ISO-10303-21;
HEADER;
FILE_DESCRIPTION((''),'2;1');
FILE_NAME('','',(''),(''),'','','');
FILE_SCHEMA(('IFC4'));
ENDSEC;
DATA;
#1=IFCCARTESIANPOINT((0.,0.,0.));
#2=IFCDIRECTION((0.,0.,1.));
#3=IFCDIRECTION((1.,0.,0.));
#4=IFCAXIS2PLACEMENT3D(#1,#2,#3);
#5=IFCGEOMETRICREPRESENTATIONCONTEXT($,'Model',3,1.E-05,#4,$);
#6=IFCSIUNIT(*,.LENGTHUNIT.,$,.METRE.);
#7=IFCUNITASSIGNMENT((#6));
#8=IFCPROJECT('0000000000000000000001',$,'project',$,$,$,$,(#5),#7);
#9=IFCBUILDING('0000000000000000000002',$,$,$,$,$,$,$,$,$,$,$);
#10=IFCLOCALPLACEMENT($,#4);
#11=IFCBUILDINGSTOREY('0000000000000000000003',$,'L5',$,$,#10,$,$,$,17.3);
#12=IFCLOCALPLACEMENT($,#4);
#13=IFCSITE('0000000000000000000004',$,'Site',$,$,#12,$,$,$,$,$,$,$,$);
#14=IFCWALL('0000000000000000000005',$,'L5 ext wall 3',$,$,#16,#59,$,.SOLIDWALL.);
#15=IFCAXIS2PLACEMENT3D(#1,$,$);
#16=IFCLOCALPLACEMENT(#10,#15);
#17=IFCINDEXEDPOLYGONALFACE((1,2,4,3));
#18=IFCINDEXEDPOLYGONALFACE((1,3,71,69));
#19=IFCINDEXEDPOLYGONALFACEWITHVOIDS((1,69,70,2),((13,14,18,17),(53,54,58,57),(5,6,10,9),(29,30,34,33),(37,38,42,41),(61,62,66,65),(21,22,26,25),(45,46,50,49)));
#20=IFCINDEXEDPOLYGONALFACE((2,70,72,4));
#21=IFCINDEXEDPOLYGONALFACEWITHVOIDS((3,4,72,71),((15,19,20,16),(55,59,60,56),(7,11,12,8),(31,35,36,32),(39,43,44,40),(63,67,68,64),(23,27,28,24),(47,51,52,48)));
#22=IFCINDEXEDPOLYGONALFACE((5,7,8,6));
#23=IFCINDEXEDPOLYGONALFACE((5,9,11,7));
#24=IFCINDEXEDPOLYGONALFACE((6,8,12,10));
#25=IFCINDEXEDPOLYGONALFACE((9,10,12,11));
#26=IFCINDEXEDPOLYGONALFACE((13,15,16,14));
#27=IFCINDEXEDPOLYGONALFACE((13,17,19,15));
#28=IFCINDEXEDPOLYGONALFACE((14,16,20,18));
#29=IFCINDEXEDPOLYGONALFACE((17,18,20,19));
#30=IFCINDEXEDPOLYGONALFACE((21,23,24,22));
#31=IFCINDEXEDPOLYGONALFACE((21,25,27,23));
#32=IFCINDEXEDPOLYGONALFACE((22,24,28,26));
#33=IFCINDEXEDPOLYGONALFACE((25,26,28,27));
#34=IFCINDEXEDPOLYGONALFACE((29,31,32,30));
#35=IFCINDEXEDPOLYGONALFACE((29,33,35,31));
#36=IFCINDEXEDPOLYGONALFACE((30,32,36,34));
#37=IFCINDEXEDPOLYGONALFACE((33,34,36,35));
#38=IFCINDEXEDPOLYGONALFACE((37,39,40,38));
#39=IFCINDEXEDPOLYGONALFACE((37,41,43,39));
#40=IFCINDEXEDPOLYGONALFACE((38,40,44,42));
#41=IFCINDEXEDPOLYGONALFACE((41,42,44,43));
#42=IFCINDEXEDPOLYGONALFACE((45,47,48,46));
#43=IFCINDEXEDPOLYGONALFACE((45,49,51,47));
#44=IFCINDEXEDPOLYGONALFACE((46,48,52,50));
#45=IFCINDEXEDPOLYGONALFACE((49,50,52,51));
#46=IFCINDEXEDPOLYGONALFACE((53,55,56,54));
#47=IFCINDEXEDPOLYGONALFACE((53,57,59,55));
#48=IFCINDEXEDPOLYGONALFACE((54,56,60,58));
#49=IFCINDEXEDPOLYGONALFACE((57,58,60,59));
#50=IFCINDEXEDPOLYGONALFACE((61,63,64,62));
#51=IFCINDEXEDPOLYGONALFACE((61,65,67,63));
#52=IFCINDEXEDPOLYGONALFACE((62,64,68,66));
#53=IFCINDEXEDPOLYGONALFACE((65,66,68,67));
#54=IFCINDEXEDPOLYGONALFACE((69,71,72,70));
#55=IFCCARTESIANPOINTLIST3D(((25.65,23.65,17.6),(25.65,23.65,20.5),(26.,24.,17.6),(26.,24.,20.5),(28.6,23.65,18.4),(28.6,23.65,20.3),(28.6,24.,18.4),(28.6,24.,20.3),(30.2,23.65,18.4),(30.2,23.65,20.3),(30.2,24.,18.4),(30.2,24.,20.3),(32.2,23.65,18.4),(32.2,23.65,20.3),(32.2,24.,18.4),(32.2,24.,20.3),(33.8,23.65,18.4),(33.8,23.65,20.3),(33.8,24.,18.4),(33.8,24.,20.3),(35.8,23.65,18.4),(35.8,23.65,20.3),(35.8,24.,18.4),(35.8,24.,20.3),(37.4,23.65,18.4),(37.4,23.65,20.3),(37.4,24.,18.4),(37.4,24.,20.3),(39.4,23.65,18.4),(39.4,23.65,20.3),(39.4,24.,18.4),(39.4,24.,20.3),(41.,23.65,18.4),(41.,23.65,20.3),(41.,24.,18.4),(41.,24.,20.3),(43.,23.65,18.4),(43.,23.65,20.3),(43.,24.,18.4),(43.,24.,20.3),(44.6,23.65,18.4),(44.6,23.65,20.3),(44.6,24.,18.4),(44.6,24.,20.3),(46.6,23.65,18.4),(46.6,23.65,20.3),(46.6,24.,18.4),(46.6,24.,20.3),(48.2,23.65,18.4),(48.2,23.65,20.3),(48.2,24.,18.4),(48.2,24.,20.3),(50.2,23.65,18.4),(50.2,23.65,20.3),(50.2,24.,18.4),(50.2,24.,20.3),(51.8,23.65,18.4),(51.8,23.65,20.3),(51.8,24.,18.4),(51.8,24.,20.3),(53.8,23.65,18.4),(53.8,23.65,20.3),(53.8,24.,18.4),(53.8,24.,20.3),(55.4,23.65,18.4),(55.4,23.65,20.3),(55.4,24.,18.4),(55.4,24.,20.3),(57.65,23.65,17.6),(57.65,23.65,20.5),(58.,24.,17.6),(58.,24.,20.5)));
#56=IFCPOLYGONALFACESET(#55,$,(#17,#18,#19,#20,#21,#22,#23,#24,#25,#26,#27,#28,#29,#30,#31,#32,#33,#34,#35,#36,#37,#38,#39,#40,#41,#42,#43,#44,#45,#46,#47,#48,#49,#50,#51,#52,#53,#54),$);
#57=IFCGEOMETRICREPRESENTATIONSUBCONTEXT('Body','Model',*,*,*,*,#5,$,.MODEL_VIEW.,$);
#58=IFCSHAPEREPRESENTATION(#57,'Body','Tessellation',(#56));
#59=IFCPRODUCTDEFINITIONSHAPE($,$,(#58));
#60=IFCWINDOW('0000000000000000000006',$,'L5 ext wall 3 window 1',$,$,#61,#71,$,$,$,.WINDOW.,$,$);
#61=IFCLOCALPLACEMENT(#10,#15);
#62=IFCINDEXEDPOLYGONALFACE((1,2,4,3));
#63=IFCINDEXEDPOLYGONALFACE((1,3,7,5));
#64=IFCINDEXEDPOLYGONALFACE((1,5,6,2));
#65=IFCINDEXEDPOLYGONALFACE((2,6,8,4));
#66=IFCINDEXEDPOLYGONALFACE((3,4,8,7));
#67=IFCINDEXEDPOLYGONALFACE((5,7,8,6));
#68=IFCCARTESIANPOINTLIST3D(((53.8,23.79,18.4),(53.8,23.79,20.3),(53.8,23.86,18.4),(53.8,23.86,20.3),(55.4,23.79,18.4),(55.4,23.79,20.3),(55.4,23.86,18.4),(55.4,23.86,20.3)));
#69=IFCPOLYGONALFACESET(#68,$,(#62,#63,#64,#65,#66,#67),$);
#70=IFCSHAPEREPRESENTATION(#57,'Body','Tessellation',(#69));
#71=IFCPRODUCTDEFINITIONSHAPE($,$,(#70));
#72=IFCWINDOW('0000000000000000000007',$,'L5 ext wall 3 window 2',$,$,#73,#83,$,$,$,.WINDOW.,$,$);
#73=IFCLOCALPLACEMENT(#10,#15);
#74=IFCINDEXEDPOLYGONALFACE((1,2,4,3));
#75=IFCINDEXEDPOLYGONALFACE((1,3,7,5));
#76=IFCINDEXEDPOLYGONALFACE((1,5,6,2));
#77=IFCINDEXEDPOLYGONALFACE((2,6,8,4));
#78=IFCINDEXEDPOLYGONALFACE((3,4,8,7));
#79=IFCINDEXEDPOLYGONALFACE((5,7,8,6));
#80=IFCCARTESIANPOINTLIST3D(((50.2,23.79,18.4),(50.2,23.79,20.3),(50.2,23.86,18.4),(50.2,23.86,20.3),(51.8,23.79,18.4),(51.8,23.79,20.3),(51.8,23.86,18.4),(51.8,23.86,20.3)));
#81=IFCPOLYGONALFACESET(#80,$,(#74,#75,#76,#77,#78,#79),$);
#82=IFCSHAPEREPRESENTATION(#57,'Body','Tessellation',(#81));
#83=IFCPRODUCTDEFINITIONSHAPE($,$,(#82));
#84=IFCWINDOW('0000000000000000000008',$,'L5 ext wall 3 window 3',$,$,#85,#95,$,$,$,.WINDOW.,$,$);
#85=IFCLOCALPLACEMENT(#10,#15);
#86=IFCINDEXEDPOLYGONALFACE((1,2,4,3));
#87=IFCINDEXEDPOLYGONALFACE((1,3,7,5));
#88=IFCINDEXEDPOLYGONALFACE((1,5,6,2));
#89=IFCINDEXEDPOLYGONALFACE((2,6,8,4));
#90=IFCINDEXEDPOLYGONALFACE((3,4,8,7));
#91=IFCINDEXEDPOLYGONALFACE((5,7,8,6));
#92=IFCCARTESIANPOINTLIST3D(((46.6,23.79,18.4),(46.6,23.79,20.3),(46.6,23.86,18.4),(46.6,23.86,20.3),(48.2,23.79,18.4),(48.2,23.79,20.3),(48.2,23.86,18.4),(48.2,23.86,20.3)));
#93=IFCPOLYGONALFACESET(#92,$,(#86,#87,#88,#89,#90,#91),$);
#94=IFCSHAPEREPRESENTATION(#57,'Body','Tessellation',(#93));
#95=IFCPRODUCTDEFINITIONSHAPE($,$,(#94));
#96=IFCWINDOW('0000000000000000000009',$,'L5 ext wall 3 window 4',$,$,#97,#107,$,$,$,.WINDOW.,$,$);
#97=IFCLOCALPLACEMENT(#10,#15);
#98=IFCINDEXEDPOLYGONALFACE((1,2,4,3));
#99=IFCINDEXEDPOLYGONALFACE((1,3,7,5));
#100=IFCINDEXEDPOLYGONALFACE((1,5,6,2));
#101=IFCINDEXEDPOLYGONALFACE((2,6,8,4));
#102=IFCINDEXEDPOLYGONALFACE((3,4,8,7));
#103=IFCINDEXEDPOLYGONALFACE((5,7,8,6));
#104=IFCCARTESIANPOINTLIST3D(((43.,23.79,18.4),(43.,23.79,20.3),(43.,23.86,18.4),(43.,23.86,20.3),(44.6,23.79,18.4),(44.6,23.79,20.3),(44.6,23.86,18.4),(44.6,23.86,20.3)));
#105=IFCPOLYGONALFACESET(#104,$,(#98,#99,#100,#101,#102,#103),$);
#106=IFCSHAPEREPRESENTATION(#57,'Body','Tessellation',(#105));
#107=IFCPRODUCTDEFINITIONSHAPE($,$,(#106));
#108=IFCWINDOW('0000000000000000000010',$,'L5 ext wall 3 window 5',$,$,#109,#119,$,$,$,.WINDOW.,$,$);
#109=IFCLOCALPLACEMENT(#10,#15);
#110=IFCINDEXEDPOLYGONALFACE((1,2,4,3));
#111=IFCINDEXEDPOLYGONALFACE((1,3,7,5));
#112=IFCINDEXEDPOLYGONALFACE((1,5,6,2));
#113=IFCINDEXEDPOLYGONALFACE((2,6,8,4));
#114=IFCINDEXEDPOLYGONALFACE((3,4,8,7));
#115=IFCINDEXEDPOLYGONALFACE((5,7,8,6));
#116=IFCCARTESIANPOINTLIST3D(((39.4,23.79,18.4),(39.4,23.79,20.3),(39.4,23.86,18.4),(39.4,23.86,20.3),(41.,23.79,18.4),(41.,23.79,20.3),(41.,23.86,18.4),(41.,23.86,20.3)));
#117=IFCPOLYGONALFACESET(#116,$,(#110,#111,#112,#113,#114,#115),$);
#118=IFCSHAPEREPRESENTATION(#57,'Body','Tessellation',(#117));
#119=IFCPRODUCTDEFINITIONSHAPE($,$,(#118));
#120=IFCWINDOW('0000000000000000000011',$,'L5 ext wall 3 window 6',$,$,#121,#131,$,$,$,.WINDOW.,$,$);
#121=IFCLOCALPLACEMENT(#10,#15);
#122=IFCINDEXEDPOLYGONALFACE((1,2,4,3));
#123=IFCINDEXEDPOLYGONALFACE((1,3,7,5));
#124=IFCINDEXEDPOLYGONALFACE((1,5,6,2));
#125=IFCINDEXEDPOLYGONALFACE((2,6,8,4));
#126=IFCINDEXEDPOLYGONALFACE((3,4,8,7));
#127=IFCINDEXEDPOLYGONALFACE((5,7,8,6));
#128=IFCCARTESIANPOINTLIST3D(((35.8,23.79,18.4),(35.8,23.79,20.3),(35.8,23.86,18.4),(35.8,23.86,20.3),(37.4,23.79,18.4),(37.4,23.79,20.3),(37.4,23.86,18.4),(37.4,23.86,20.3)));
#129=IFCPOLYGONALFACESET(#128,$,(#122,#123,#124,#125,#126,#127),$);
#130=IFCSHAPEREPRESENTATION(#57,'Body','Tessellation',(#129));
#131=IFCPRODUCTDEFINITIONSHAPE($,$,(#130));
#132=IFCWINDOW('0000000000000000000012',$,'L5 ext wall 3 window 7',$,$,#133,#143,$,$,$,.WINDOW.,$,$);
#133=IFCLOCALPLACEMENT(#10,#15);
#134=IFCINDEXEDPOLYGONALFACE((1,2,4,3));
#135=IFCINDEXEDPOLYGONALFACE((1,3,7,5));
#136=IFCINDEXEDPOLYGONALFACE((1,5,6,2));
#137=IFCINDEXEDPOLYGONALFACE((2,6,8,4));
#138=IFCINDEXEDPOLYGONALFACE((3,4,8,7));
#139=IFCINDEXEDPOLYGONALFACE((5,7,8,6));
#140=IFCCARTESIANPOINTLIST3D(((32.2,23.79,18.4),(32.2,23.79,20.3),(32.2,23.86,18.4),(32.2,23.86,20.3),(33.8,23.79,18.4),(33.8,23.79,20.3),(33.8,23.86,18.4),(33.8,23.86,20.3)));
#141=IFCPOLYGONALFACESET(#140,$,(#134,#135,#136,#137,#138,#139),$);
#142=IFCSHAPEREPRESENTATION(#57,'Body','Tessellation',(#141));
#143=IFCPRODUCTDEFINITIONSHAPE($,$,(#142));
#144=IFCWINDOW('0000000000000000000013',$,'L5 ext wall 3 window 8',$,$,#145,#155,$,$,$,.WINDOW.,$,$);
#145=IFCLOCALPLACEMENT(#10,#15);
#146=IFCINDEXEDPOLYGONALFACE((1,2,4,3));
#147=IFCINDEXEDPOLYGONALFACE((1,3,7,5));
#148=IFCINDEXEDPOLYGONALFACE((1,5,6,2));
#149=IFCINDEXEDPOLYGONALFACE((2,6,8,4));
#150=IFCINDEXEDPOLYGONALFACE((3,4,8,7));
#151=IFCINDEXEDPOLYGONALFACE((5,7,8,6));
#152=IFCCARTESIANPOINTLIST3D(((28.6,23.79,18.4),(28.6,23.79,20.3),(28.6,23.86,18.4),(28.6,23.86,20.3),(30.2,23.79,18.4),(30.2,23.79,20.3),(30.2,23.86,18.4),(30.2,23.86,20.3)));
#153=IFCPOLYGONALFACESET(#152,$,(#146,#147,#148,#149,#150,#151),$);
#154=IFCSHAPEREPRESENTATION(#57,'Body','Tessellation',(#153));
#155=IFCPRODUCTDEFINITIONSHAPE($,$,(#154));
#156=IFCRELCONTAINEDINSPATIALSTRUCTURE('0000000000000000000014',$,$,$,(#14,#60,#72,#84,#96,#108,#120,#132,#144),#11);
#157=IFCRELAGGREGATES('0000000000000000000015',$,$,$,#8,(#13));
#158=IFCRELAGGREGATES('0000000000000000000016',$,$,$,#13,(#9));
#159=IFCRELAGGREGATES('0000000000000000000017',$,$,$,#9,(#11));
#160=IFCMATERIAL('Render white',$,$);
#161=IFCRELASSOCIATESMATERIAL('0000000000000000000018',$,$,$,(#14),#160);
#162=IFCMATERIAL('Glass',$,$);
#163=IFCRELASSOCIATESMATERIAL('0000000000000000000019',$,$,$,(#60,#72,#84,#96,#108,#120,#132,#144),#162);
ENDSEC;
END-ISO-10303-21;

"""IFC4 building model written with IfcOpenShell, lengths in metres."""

from ifc_helpers import new_model, si_unit, frame, origin_with_axes, place, context, subcontext, project, spatial, polyline, outline, extrude, material, element, fill, save


model = new_model("IFC4")

# Units and contexts
model_context = context("Model", 3, precision=1e-05, world=origin_with_axes())
body_context = subcontext(model_context, "Body", "Model", "MODEL_VIEW")
ifc_project = project(units=[si_unit("LENGTHUNIT", "METRE")], contexts=[model_context])

# Site, building, storey
site_placement = place(None, origin_with_axes())
site = spatial("IfcSite", under=ifc_project, at=site_placement, Name="Site")
building = spatial("IfcBuilding", under=site)
storey_placement = place(None, origin_with_axes())
storey = spatial("IfcBuildingStorey", under=building, at=storey_placement, Name="L5", Elevation=17.3)

# Wall, openings, windows
ifc_material_1 = material(Name="Render white")
wall_1_placement = place(storey_placement, origin_with_axes())
wall_1 = element("IfcWall", 1, at=wall_1_placement, inside=storey, material=ifc_material_1, Name="L5 ext wall 3", PredefinedType="SOLIDWALL", context=body_context, shape_type="SweptSolid", body=[
    extrude(outline(polyline([(58.0, 24.0), (26.0, 24.0), (25.65, 23.65), (57.65, 23.65), (58.0, 24.0)])), frame((0.0, 0.0, 17.6), z_axis=(0.0, 0.0, 1.0), x_axis=(1.0, 0.0, 0.0)), (0.0, 0.0, 1.0), 2.9),
])
opening_1_placement = place(wall_1_placement, origin_with_axes())
opening_1 = element("IfcOpeningElement", 2, at=opening_1_placement, cuts=wall_1, context=body_context, shape_type="SweptSolid", body=[
    extrude(outline(polyline([(55.4, 24.05), (53.8, 24.05), (53.8, 23.6), (55.4, 23.6), (55.4, 24.05)])), frame((0.0, 0.0, 18.4), z_axis=(0.0, 0.0, 1.0), x_axis=(1.0, 0.0, 0.0)), (0.0, 0.0, 1.0), 1.9),
])
opening_2_placement = place(wall_1_placement, origin_with_axes())
opening_2 = element("IfcOpeningElement", 3, at=opening_2_placement, cuts=wall_1, context=body_context, shape_type="SweptSolid", body=[
    extrude(outline(polyline([(51.8, 24.05), (50.2, 24.05), (50.2, 23.6), (51.8, 23.6), (51.8, 24.05)])), frame((0.0, 0.0, 18.4), z_axis=(0.0, 0.0, 1.0), x_axis=(1.0, 0.0, 0.0)), (0.0, 0.0, 1.0), 1.9),
])
opening_3_placement = place(wall_1_placement, origin_with_axes())
opening_3 = element("IfcOpeningElement", 4, at=opening_3_placement, cuts=wall_1, context=body_context, shape_type="SweptSolid", body=[
    extrude(outline(polyline([(48.2, 24.05), (46.6, 24.05), (46.6, 23.6), (48.2, 23.6), (48.2, 24.05)])), frame((0.0, 0.0, 18.4), z_axis=(0.0, 0.0, 1.0), x_axis=(1.0, 0.0, 0.0)), (0.0, 0.0, 1.0), 1.9),
])
opening_4_placement = place(wall_1_placement, origin_with_axes())
opening_4 = element("IfcOpeningElement", 5, at=opening_4_placement, cuts=wall_1, context=body_context, shape_type="SweptSolid", body=[
    extrude(outline(polyline([(44.6, 24.05), (43.0, 24.05), (43.0, 23.6), (44.6, 23.6), (44.6, 24.05)])), frame((0.0, 0.0, 18.4), z_axis=(0.0, 0.0, 1.0), x_axis=(1.0, 0.0, 0.0)), (0.0, 0.0, 1.0), 1.9),
])
opening_5_placement = place(wall_1_placement, origin_with_axes())
opening_5 = element("IfcOpeningElement", 6, at=opening_5_placement, cuts=wall_1, context=body_context, shape_type="SweptSolid", body=[
    extrude(outline(polyline([(41.0, 24.05), (39.4, 24.05), (39.4, 23.6), (41.0, 23.6), (41.0, 24.05)])), frame((0.0, 0.0, 18.4), z_axis=(0.0, 0.0, 1.0), x_axis=(1.0, 0.0, 0.0)), (0.0, 0.0, 1.0), 1.9),
])
opening_6_placement = place(wall_1_placement, origin_with_axes())
opening_6 = element("IfcOpeningElement", 7, at=opening_6_placement, cuts=wall_1, context=body_context, shape_type="SweptSolid", body=[
    extrude(outline(polyline([(37.4, 24.05), (35.8, 24.05), (35.8, 23.6), (37.4, 23.6), (37.4, 24.05)])), frame((0.0, 0.0, 18.4), z_axis=(0.0, 0.0, 1.0), x_axis=(1.0, 0.0, 0.0)), (0.0, 0.0, 1.0), 1.9),
])
opening_7_placement = place(wall_1_placement, origin_with_axes())
opening_7 = element("IfcOpeningElement", 8, at=opening_7_placement, cuts=wall_1, context=body_context, shape_type="SweptSolid", body=[
    extrude(outline(polyline([(33.8, 24.05), (32.2, 24.05), (32.2, 23.6), (33.8, 23.6), (33.8, 24.05)])), frame((0.0, 0.0, 18.4), z_axis=(0.0, 0.0, 1.0), x_axis=(1.0, 0.0, 0.0)), (0.0, 0.0, 1.0), 1.9),
])
opening_8_placement = place(wall_1_placement, origin_with_axes())
opening_8 = element("IfcOpeningElement", 9, at=opening_8_placement, cuts=wall_1, context=body_context, shape_type="SweptSolid", body=[
    extrude(outline(polyline([(30.2, 24.05), (28.6, 24.05), (28.6, 23.6), (30.2, 23.6), (30.2, 24.05)])), frame((0.0, 0.0, 18.4), z_axis=(0.0, 0.0, 1.0), x_axis=(1.0, 0.0, 0.0)), (0.0, 0.0, 1.0), 1.9),
])
ifc_material_2 = material(Name="Glass")
window_1_placement = place(storey_placement, origin_with_axes())
window_1 = element("IfcWindow", 10, at=window_1_placement, inside=storey, material=ifc_material_2, Name="L5 ext wall 3 window 1", PredefinedType="WINDOW", context=body_context, shape_type="SweptSolid", body=[
    extrude(outline(polyline([(55.4, 23.86), (53.8, 23.86), (53.8, 23.79), (55.4, 23.79), (55.4, 23.86)])), frame((0.0, 0.0, 18.4), z_axis=(0.0, 0.0, 1.0), x_axis=(1.0, 0.0, 0.0)), (0.0, 0.0, 1.0), 1.9),
])
fill(opening_1, window_1)
window_2_placement = place(storey_placement, origin_with_axes())
window_2 = element("IfcWindow", 11, at=window_2_placement, inside=storey, material=ifc_material_2, Name="L5 ext wall 3 window 2", PredefinedType="WINDOW", context=body_context, shape_type="SweptSolid", body=[
    extrude(outline(polyline([(51.8, 23.86), (50.2, 23.86), (50.2, 23.79), (51.8, 23.79), (51.8, 23.86)])), frame((0.0, 0.0, 18.4), z_axis=(0.0, 0.0, 1.0), x_axis=(1.0, 0.0, 0.0)), (0.0, 0.0, 1.0), 1.9),
])
fill(opening_2, window_2)
window_3_placement = place(storey_placement, origin_with_axes())
window_3 = element("IfcWindow", 12, at=window_3_placement, inside=storey, material=ifc_material_2, Name="L5 ext wall 3 window 3", PredefinedType="WINDOW", context=body_context, shape_type="SweptSolid", body=[
    extrude(outline(polyline([(48.2, 23.86), (46.6, 23.86), (46.6, 23.79), (48.2, 23.79), (48.2, 23.86)])), frame((0.0, 0.0, 18.4), z_axis=(0.0, 0.0, 1.0), x_axis=(1.0, 0.0, 0.0)), (0.0, 0.0, 1.0), 1.9),
])
fill(opening_3, window_3)
window_4_placement = place(storey_placement, origin_with_axes())
window_4 = element("IfcWindow", 13, at=window_4_placement, inside=storey, material=ifc_material_2, Name="L5 ext wall 3 window 4", PredefinedType="WINDOW", context=body_context, shape_type="SweptSolid", body=[
    extrude(outline(polyline([(44.6, 23.86), (43.0, 23.86), (43.0, 23.79), (44.6, 23.79), (44.6, 23.86)])), frame((0.0, 0.0, 18.4), z_axis=(0.0, 0.0, 1.0), x_axis=(1.0, 0.0, 0.0)), (0.0, 0.0, 1.0), 1.9),
])
fill(opening_4, window_4)
window_5_placement = place(storey_placement, origin_with_axes())
window_5 = element("IfcWindow", 14, at=window_5_placement, inside=storey, material=ifc_material_2, Name="L5 ext wall 3 window 5", PredefinedType="WINDOW", context=body_context, shape_type="SweptSolid", body=[
    extrude(outline(polyline([(41.0, 23.86), (39.4, 23.86), (39.4, 23.79), (41.0, 23.79), (41.0, 23.86)])), frame((0.0, 0.0, 18.4), z_axis=(0.0, 0.0, 1.0), x_axis=(1.0, 0.0, 0.0)), (0.0, 0.0, 1.0), 1.9),
])
fill(opening_5, window_5)
window_6_placement = place(storey_placement, origin_with_axes())
window_6 = element("IfcWindow", 15, at=window_6_placement, inside=storey, material=ifc_material_2, Name="L5 ext wall 3 window 6", PredefinedType="WINDOW", context=body_context, shape_type="SweptSolid", body=[
    extrude(outline(polyline([(37.4, 23.86), (35.8, 23.86), (35.8, 23.79), (37.4, 23.79), (37.4, 23.86)])), frame((0.0, 0.0, 18.4), z_axis=(0.0, 0.0, 1.0), x_axis=(1.0, 0.0, 0.0)), (0.0, 0.0, 1.0), 1.9),
])
fill(opening_6, window_6)
window_7_placement = place(storey_placement, origin_with_axes())
window_7 = element("IfcWindow", 16, at=window_7_placement, inside=storey, material=ifc_material_2, Name="L5 ext wall 3 window 7", PredefinedType="WINDOW", context=body_context, shape_type="SweptSolid", body=[
    extrude(outline(polyline([(33.8, 23.86), (32.2, 23.86), (32.2, 23.79), (33.8, 23.79), (33.8, 23.86)])), frame((0.0, 0.0, 18.4), z_axis=(0.0, 0.0, 1.0), x_axis=(1.0, 0.0, 0.0)), (0.0, 0.0, 1.0), 1.9),
])
fill(opening_7, window_7)
window_8_placement = place(storey_placement, origin_with_axes())
window_8 = element("IfcWindow", 17, at=window_8_placement, inside=storey, material=ifc_material_2, Name="L5 ext wall 3 window 8", PredefinedType="WINDOW", context=body_context, shape_type="SweptSolid", body=[
    extrude(outline(polyline([(30.2, 23.86), (28.6, 23.86), (28.6, 23.79), (30.2, 23.79), (30.2, 23.86)])), frame((0.0, 0.0, 18.4), z_axis=(0.0, 0.0, 1.0), x_axis=(1.0, 0.0, 0.0)), (0.0, 0.0, 1.0), 1.9),
])
fill(opening_8, window_8)

save(model, "model.ifc")
